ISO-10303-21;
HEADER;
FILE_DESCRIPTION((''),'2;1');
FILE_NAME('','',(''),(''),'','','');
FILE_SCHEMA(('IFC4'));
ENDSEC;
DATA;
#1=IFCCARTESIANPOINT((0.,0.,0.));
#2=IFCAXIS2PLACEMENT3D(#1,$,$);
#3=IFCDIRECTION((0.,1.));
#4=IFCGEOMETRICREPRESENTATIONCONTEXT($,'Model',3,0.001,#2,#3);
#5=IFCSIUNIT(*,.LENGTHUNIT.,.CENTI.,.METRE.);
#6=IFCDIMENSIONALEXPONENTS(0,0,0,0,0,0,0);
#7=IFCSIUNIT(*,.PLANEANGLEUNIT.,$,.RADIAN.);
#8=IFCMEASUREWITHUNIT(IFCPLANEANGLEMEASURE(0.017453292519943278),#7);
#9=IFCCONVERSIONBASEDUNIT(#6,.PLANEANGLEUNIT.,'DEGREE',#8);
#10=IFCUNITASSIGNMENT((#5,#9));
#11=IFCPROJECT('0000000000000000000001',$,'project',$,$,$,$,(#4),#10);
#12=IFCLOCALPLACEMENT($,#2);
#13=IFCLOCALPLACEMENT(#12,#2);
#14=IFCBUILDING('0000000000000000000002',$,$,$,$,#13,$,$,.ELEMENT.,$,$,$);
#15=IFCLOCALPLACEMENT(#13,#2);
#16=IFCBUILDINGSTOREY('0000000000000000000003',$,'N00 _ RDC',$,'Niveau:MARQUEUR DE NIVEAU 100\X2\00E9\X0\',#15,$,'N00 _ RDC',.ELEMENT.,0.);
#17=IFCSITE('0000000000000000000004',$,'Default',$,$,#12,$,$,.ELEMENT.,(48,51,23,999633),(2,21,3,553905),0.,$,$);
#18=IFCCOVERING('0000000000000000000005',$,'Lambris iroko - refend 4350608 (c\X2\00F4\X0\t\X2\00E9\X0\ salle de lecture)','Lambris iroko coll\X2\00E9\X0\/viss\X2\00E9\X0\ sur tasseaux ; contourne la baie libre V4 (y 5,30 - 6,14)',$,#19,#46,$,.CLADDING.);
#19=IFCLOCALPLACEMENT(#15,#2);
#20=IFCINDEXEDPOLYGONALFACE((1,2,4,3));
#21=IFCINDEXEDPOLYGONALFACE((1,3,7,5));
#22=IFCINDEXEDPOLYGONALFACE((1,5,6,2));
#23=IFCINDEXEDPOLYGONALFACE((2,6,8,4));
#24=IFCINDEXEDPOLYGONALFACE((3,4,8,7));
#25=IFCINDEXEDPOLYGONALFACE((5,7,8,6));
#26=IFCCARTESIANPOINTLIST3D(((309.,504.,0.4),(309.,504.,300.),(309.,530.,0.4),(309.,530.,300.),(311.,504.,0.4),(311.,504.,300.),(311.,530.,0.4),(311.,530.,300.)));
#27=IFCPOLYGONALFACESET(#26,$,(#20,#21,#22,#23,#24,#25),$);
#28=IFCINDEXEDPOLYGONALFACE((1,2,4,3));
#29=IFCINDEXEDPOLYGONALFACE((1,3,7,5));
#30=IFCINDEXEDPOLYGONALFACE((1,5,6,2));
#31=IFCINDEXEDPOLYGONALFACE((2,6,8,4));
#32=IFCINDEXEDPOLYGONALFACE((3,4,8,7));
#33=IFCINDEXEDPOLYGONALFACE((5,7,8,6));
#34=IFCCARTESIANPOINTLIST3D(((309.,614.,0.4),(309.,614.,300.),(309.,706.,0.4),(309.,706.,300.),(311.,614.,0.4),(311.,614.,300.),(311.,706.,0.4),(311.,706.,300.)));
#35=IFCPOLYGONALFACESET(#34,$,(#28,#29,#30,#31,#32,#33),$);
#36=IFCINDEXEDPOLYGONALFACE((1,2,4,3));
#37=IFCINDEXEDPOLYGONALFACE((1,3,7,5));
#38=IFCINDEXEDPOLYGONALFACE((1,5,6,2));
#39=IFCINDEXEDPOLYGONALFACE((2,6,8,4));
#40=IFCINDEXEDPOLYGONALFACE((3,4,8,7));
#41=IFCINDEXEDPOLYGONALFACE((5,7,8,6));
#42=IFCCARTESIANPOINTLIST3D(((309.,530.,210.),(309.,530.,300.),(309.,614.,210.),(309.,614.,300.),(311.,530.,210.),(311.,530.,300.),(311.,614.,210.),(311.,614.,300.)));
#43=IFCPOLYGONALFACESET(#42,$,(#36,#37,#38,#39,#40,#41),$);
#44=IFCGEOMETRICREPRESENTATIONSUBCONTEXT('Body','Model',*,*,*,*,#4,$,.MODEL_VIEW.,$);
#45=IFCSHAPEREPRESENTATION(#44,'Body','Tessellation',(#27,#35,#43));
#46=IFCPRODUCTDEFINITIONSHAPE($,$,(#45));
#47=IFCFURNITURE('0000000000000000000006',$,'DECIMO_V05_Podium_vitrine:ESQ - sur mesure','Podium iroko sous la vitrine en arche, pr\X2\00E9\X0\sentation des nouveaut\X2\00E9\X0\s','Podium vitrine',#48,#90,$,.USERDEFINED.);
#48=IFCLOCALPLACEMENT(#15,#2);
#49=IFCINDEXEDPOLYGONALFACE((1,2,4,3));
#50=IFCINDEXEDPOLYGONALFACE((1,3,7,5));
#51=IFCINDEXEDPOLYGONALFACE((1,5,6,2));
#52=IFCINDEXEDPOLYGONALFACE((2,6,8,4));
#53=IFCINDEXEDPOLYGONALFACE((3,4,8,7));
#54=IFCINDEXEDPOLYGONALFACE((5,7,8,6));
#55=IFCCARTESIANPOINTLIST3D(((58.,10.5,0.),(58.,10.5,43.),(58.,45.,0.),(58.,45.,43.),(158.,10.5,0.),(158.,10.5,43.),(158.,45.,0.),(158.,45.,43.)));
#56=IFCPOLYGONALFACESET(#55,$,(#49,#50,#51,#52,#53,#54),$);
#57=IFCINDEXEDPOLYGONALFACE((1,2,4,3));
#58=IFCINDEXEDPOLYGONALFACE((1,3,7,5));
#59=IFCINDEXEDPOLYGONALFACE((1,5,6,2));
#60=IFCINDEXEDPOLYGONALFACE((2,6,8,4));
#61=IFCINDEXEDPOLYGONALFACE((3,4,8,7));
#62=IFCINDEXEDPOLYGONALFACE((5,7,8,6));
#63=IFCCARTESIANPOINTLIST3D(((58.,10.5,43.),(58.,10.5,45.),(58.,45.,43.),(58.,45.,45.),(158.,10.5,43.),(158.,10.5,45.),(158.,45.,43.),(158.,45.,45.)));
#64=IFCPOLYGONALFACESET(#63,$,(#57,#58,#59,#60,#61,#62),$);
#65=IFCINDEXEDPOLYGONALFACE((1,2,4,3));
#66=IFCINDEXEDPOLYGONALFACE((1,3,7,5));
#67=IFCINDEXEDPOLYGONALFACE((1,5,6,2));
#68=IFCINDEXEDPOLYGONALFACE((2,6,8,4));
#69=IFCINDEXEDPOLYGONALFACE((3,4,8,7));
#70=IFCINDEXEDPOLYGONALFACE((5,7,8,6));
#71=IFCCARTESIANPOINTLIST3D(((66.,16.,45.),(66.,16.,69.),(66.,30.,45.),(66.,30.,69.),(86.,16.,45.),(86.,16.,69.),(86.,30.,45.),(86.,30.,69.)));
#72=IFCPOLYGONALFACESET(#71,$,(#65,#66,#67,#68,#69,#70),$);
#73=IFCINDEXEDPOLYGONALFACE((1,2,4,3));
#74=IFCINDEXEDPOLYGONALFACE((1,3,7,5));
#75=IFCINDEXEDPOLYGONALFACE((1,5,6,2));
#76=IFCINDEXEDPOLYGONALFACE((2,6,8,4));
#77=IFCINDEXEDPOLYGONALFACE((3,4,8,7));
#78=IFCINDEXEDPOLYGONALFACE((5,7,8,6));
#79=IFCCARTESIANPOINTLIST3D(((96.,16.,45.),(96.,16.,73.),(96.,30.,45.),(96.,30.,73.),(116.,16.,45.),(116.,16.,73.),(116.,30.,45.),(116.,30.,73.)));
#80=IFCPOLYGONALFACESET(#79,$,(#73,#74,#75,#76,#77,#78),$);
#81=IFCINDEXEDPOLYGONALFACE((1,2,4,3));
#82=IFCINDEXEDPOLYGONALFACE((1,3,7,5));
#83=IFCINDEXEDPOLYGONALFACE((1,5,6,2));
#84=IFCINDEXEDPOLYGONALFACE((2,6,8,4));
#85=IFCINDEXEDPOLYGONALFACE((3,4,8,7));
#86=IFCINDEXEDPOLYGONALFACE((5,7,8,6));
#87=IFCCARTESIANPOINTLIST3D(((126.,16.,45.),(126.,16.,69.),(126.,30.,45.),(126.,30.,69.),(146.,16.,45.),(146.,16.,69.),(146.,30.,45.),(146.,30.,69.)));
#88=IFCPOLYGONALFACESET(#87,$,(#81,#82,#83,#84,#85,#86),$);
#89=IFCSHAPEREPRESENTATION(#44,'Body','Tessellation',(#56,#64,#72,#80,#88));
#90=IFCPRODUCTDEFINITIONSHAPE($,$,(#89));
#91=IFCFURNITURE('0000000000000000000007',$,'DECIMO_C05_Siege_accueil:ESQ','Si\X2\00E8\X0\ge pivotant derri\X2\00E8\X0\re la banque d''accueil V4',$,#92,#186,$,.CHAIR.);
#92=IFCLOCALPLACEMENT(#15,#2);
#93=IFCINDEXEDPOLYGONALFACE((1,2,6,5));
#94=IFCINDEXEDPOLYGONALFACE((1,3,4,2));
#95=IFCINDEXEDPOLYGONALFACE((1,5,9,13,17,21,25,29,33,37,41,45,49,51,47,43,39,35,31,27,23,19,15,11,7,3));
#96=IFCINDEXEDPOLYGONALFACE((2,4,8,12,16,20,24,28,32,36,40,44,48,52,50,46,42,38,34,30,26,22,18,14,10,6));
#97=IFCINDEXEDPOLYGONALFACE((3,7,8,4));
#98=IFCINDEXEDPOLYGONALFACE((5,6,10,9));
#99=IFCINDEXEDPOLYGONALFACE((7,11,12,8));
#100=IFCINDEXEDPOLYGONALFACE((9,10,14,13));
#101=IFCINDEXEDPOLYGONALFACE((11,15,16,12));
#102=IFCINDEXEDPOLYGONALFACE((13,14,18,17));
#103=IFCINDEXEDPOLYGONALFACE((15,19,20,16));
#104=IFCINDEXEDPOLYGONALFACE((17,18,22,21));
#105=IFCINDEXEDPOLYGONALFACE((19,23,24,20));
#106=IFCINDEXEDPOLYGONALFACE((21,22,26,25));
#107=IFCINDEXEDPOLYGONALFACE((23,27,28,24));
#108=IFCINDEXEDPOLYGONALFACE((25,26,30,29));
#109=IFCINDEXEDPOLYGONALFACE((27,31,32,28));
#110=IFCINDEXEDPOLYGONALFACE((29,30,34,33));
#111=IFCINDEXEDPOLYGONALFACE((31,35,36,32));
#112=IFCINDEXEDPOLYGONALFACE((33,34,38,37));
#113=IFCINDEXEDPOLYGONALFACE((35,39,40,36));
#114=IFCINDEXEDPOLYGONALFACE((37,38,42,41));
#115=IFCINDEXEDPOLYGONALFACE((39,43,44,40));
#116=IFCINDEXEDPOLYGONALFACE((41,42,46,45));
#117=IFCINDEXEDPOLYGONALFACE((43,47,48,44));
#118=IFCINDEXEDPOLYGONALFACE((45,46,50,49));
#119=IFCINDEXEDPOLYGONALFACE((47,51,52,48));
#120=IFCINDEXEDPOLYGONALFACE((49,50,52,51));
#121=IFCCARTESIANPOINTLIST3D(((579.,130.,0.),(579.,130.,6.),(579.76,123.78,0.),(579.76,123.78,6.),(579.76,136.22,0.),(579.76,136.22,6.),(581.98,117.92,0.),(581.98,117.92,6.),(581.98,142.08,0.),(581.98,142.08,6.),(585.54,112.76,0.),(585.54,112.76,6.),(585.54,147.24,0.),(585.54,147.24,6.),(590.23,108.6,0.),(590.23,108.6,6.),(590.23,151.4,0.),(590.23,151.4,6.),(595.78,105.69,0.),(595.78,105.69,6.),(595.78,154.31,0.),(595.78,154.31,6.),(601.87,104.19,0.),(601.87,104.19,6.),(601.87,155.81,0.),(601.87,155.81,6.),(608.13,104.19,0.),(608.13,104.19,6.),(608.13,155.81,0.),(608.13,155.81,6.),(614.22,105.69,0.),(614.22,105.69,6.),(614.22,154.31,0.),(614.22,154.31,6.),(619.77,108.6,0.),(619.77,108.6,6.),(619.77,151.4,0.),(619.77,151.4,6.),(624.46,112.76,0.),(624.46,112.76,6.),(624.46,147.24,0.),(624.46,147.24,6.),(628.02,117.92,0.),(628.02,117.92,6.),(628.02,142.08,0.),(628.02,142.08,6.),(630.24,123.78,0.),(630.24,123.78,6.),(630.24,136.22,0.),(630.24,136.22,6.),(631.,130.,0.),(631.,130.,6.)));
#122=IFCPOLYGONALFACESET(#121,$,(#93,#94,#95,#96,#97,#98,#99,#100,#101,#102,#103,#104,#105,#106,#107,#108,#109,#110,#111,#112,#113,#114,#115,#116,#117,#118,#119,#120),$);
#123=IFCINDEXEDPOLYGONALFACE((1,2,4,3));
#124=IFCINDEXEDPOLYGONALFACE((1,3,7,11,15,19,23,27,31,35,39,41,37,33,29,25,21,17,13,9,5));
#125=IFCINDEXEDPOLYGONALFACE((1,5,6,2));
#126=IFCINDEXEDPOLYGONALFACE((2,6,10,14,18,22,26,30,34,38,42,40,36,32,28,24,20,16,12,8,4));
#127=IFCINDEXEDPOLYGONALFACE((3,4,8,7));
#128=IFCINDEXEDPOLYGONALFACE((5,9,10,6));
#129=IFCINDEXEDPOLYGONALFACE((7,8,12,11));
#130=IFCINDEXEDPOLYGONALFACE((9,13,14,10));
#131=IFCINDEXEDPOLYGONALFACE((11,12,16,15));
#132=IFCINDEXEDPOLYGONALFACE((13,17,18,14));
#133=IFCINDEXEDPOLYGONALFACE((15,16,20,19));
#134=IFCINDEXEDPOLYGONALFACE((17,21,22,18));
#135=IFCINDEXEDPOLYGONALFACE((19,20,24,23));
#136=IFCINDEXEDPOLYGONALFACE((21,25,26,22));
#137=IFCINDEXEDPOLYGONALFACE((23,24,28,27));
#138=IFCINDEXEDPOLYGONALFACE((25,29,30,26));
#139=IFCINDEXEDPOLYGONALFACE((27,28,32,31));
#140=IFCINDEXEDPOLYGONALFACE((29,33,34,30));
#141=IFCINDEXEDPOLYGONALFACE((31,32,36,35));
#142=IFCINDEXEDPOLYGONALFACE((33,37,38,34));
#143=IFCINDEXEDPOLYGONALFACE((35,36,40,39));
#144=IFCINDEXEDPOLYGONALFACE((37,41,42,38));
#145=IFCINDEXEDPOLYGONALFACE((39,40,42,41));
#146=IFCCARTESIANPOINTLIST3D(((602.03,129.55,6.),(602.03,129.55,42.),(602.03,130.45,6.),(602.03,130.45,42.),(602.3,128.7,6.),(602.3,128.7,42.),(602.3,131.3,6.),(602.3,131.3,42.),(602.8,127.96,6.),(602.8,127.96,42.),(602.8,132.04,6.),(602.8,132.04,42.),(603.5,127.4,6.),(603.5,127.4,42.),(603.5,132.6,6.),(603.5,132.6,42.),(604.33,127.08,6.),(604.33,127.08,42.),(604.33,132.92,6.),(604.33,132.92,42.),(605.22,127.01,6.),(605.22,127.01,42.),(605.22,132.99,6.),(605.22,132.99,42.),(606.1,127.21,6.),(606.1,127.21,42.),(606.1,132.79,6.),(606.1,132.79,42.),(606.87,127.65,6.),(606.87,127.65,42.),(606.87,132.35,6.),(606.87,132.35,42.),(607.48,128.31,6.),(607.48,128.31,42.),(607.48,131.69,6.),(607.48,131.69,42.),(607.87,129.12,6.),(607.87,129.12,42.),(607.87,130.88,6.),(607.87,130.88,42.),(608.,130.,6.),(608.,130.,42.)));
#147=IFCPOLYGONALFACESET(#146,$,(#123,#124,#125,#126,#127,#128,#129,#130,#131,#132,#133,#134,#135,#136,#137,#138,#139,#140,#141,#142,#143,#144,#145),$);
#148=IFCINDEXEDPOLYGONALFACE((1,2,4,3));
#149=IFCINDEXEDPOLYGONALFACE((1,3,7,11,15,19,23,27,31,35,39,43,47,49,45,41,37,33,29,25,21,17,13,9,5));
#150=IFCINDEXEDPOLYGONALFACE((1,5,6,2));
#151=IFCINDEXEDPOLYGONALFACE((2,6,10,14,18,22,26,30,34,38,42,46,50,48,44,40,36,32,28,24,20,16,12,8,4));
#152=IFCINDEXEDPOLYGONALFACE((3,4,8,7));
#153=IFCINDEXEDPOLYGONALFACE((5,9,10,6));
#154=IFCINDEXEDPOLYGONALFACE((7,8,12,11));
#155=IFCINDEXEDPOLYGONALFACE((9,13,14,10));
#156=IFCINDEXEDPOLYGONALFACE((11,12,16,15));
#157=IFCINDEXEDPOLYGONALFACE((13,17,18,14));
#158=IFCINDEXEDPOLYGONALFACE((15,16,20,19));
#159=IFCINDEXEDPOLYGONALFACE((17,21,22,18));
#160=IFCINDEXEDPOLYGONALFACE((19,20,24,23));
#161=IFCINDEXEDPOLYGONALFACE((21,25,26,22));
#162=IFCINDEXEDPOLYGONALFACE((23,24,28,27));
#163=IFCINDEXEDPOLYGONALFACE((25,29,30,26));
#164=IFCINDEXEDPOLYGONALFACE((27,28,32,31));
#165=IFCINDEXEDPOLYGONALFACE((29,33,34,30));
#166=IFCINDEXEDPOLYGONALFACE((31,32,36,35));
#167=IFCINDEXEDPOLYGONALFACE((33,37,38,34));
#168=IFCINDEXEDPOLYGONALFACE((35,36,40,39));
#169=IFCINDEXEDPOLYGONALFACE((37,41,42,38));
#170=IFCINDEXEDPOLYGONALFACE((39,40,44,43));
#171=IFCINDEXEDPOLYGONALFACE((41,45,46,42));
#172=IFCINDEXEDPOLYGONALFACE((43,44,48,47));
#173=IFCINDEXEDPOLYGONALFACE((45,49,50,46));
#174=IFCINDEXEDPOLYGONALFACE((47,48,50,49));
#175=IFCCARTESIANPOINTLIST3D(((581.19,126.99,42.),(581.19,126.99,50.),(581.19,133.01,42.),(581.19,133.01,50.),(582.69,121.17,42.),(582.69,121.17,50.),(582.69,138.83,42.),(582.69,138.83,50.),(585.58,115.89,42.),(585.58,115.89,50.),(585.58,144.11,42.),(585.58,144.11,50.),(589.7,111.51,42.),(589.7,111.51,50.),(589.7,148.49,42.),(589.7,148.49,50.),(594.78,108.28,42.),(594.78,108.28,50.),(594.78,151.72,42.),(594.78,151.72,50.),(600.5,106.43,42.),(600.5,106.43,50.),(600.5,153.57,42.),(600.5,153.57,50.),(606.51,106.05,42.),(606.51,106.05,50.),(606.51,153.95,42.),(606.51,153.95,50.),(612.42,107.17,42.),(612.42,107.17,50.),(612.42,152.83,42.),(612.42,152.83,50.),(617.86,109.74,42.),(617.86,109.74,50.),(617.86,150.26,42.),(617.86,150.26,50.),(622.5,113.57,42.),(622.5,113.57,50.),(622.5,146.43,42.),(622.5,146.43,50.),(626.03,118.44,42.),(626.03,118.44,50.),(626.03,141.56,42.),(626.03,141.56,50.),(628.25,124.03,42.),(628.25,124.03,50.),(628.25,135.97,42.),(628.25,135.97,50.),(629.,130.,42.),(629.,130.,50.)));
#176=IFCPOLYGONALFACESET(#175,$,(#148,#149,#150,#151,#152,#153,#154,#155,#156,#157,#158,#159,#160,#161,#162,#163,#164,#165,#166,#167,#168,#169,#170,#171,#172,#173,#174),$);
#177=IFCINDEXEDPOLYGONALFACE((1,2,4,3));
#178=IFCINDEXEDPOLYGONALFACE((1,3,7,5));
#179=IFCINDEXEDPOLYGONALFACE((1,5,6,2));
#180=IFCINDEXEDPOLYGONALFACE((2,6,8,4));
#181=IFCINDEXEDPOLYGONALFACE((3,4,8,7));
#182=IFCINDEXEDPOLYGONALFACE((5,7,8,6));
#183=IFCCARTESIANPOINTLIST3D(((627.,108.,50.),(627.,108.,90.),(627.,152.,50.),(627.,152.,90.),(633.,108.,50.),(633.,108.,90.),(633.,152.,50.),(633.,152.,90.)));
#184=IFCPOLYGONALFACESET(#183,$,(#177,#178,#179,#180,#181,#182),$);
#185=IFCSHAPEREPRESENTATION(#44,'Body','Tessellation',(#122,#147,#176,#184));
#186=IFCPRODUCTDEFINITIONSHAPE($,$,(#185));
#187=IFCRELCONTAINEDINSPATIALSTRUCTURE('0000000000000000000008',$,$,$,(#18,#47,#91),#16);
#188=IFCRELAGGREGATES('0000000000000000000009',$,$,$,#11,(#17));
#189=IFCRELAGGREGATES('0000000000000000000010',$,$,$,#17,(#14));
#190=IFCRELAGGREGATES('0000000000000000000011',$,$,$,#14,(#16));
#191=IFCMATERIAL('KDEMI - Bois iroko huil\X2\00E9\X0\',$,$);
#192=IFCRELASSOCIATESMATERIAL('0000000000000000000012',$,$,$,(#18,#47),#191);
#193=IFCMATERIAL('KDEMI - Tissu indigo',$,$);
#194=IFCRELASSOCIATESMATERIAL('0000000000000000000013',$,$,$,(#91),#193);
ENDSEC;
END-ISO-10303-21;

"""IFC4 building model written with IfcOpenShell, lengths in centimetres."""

from ifc_helpers import new_model, entity, si_unit, converted_unit, direction, frame, frame_2d, origin, origin_with_axes, place, context, subcontext, project, spatial, rectangle, circle, extrude, material, element, save


model = new_model("IFC4")

# Units and contexts
model_context = context("Model", 3, precision=0.001, world=origin(), true_north=direction((0.0, 1.0)))
body_context = subcontext(model_context, "Body", "Model", "MODEL_VIEW")
ifc_project = project(units=[si_unit("LENGTHUNIT", "METRE", prefix="CENTI"), converted_unit("PLANEANGLEUNIT", "DEGREE", entity("IfcPlaneAngleMeasure", 0.017453292519943278), si_unit("PLANEANGLEUNIT", "RADIAN"), dimensions=[0, 0, 0, 0, 0, 0, 0])], contexts=[model_context])

# Site, building, storey
site_placement = place(None, origin())
site = spatial("IfcSite", under=ifc_project, at=site_placement, Name="Default", CompositionType="ELEMENT", RefLatitude=(48, 51, 23, 999633), RefLongitude=(2, 21, 3, 553905), RefElevation=0.0)
building_placement = place(site_placement, origin())
building = spatial("IfcBuilding", under=site, at=building_placement, CompositionType="ELEMENT")
storey_placement = place(building_placement, origin())
storey = spatial("IfcBuildingStorey", under=building, at=storey_placement, Name="N00 _ RDC", ObjectType="Niveau:MARQUEUR DE NIVEAU 100é", LongName="N00 _ RDC", CompositionType="ELEMENT", Elevation=0.0)

# Covering
ifc_material_1 = material(Name="KDEMI - Bois iroko huilé")
covering_1_placement = place(storey_placement, origin_with_axes())
element("IfcCovering", 1, at=covering_1_placement, inside=storey, material=ifc_material_1, Name="Lambris iroko - refend 4350608 (côté salle de lecture)", Description="Lambris iroko collé/vissé sur tasseaux ; contourne la baie libre V4 (y 5,30 - 6,14)", PredefinedType="CLADDING", context=body_context, shape_type="SweptSolid", body=[
    extrude(rectangle(XDim=2.0, YDim=26.0, at=frame_2d((310.0, 517.0))), frame((0.0, 0.0, 0.4)), (0.0, 0.0, 1.0), 299.6),
    extrude(rectangle(XDim=2.0, YDim=92.0, at=frame_2d((310.0, 660.0))), frame((0.0, 0.0, 0.4)), (0.0, 0.0, 1.0), 299.6),
    extrude(rectangle(XDim=2.0, YDim=84.0, at=frame_2d((310.0, 572.0))), frame((0.0, 0.0, 210.0)), (0.0, 0.0, 1.0), 90.0),
])

# Furniture
furniture_1_placement = place(storey_placement, origin_with_axes())
element("IfcFurniture", 2, at=furniture_1_placement, inside=storey, material=ifc_material_1, Name="DECIMO_V05_Podium_vitrine:ESQ - sur mesure", Description="Podium iroko sous la vitrine en arche, présentation des nouveautés", ObjectType="Podium vitrine", PredefinedType="USERDEFINED", context=body_context, shape_type="SweptSolid", body=[
    extrude(rectangle(XDim=100.0, YDim=34.5, at=frame_2d((108.0, 27.75))), origin(), (0.0, 0.0, 1.0), 43.0),
    extrude(rectangle(XDim=100.0, YDim=34.5, at=frame_2d((108.0, 27.75))), frame((0.0, 0.0, 43.0)), (0.0, 0.0, 1.0), 2.0),
    extrude(rectangle(XDim=20.0, YDim=14.0, at=frame_2d((76.0, 23.0))), frame((0.0, 0.0, 45.0)), (0.0, 0.0, 1.0), 24.0),
    extrude(rectangle(XDim=20.0, YDim=14.0, at=frame_2d((106.0, 23.0))), frame((0.0, 0.0, 45.0)), (0.0, 0.0, 1.0), 28.0),
    extrude(rectangle(XDim=20.0, YDim=14.0, at=frame_2d((136.0, 23.0))), frame((0.0, 0.0, 45.0)), (0.0, 0.0, 1.0), 24.0),
])
ifc_material_2 = material(Name="KDEMI - Tissu indigo")
furniture_2_placement = place(storey_placement, origin_with_axes())
element("IfcFurniture", 3, at=furniture_2_placement, inside=storey, material=ifc_material_2, Name="DECIMO_C05_Siege_accueil:ESQ", Description="Siège pivotant derrière la banque d'accueil V4", PredefinedType="CHAIR", context=body_context, shape_type="SweptSolid", body=[
    extrude(circle(Radius=26.0, at=frame_2d((605.0, 130.0))), origin(), (0.0, 0.0, 1.0), 6.0),
    extrude(circle(Radius=3.0, at=frame_2d((605.0, 130.0))), frame((0.0, 0.0, 6.0)), (0.0, 0.0, 1.0), 36.0),
    extrude(circle(Radius=24.0, at=frame_2d((605.0, 130.0))), frame((0.0, 0.0, 42.0)), (0.0, 0.0, 1.0), 8.0),
    extrude(rectangle(XDim=6.0, YDim=44.0, at=frame_2d((630.0, 130.0))), frame((0.0, 0.0, 50.0)), (0.0, 0.0, 1.0), 40.0),
])

save(model, "model.ifc")
